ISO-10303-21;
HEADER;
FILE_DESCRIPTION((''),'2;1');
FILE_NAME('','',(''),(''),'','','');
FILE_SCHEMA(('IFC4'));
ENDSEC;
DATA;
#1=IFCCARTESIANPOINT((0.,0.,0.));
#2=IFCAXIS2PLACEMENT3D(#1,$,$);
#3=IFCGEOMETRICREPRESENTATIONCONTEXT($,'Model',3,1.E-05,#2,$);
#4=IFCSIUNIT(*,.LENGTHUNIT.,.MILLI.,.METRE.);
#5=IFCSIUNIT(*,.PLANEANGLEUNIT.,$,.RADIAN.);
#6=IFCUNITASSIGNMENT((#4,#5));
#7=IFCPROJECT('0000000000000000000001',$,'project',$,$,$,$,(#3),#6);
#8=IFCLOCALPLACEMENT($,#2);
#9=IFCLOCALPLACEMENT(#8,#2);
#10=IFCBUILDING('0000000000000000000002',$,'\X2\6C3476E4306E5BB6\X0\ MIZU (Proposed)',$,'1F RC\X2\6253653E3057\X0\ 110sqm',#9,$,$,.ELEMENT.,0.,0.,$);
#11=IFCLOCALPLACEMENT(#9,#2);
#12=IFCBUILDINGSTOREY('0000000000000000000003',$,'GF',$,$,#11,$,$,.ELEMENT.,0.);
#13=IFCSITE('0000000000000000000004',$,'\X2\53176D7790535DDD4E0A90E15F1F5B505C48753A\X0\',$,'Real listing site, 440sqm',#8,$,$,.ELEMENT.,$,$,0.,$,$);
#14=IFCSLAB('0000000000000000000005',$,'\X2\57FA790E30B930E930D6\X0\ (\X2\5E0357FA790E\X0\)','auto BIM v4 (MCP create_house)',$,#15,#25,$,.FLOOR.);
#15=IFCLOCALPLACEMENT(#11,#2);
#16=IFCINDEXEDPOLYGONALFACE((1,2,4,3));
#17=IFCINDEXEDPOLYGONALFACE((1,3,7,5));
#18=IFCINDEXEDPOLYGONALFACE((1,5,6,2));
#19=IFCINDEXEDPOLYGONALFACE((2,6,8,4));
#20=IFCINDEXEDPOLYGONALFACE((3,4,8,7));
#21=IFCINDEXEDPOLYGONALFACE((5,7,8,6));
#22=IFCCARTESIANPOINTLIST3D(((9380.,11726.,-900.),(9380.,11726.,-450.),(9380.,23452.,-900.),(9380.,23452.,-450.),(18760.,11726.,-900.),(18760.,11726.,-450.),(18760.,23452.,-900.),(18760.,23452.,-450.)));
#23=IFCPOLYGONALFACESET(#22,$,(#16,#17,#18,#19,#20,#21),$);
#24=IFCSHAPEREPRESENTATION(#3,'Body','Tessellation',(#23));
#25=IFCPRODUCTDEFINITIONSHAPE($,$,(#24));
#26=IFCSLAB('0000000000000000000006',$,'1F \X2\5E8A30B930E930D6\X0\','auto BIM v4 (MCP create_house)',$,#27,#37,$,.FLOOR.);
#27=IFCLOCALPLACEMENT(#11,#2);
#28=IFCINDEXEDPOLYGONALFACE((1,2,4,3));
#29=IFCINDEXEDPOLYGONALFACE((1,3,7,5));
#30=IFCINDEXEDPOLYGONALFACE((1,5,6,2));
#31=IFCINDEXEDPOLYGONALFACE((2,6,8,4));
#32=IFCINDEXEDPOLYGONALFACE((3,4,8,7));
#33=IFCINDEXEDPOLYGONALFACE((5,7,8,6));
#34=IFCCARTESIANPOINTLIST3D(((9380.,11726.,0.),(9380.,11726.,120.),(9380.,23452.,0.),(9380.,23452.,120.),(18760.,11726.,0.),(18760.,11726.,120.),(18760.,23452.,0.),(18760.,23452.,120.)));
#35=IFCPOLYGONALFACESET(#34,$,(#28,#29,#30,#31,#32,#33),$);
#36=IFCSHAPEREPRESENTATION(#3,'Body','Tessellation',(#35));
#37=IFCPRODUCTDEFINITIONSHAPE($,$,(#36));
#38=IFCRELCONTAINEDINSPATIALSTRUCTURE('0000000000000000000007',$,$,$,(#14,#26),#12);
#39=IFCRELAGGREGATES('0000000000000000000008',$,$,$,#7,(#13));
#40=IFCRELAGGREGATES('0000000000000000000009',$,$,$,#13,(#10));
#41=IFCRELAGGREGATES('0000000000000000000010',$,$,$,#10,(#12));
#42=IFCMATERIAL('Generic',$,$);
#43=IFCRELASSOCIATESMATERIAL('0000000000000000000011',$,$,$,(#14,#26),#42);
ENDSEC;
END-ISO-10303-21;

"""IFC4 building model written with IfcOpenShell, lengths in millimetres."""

from ifc_helpers import new_model, si_unit, frame, frame_2d, origin, place, context, project, spatial, rectangle, extrude, material, element, save


model = new_model("IFC4")

# Units and contexts
model_context = context("Model", 3, precision=1e-05, world=origin())
ifc_project = project(units=[si_unit("LENGTHUNIT", "METRE", prefix="MILLI"), si_unit("PLANEANGLEUNIT", "RADIAN")], contexts=[model_context])

# Site, building, storey
site_placement = place(None, origin())
site = spatial("IfcSite", under=ifc_project, at=site_placement, Name="北海道川上郡弟子屈町", ObjectType="Real listing site, 440sqm", CompositionType="ELEMENT", RefElevation=0.0)
building_placement = place(site_placement, origin())
building = spatial("IfcBuilding", under=site, at=building_placement, Name="水盤の家 MIZU (Proposed)", ObjectType="1F RC打放し 110sqm", CompositionType="ELEMENT", ElevationOfRefHeight=0.0, ElevationOfTerrain=0.0)
storey_placement = place(building_placement, origin())
storey = spatial("IfcBuildingStorey", under=building, at=storey_placement, Name="GF", CompositionType="ELEMENT", Elevation=0.0)

# Slabs
ifc_material = material(Name="Generic")
slab_1_placement = place(storey_placement, frame((4690.0, 5863.0, -450.0)))
element("IfcSlab", 1, at=slab_1_placement, inside=storey, material=ifc_material, Name="基礎スラブ (布基礎)", Description="auto BIM v4 (MCP create_house)", PredefinedType="FLOOR", context=model_context, shape_type="SweptSolid", body=[
    extrude(rectangle(XDim=9380.0, YDim=11726.0, at=frame_2d((4690.0, 5863.0))), frame((4690.0, 5863.0, -450.0)), (0.0, 0.0, 1.0), 450.0),
])
slab_2_placement = place(storey_placement, frame((4690.0, 5863.0, 0.0)))
element("IfcSlab", 2, at=slab_2_placement, inside=storey, material=ifc_material, Name="1F 床スラブ", Description="auto BIM v4 (MCP create_house)", PredefinedType="FLOOR", context=model_context, shape_type="SweptSolid", body=[
    extrude(rectangle(XDim=9380.0, YDim=11726.0, at=frame_2d((4690.0, 5863.0))), frame((4690.0, 5863.0, 0.0)), (0.0, 0.0, 1.0), 120.0),
])

save(model, "model.ifc")
